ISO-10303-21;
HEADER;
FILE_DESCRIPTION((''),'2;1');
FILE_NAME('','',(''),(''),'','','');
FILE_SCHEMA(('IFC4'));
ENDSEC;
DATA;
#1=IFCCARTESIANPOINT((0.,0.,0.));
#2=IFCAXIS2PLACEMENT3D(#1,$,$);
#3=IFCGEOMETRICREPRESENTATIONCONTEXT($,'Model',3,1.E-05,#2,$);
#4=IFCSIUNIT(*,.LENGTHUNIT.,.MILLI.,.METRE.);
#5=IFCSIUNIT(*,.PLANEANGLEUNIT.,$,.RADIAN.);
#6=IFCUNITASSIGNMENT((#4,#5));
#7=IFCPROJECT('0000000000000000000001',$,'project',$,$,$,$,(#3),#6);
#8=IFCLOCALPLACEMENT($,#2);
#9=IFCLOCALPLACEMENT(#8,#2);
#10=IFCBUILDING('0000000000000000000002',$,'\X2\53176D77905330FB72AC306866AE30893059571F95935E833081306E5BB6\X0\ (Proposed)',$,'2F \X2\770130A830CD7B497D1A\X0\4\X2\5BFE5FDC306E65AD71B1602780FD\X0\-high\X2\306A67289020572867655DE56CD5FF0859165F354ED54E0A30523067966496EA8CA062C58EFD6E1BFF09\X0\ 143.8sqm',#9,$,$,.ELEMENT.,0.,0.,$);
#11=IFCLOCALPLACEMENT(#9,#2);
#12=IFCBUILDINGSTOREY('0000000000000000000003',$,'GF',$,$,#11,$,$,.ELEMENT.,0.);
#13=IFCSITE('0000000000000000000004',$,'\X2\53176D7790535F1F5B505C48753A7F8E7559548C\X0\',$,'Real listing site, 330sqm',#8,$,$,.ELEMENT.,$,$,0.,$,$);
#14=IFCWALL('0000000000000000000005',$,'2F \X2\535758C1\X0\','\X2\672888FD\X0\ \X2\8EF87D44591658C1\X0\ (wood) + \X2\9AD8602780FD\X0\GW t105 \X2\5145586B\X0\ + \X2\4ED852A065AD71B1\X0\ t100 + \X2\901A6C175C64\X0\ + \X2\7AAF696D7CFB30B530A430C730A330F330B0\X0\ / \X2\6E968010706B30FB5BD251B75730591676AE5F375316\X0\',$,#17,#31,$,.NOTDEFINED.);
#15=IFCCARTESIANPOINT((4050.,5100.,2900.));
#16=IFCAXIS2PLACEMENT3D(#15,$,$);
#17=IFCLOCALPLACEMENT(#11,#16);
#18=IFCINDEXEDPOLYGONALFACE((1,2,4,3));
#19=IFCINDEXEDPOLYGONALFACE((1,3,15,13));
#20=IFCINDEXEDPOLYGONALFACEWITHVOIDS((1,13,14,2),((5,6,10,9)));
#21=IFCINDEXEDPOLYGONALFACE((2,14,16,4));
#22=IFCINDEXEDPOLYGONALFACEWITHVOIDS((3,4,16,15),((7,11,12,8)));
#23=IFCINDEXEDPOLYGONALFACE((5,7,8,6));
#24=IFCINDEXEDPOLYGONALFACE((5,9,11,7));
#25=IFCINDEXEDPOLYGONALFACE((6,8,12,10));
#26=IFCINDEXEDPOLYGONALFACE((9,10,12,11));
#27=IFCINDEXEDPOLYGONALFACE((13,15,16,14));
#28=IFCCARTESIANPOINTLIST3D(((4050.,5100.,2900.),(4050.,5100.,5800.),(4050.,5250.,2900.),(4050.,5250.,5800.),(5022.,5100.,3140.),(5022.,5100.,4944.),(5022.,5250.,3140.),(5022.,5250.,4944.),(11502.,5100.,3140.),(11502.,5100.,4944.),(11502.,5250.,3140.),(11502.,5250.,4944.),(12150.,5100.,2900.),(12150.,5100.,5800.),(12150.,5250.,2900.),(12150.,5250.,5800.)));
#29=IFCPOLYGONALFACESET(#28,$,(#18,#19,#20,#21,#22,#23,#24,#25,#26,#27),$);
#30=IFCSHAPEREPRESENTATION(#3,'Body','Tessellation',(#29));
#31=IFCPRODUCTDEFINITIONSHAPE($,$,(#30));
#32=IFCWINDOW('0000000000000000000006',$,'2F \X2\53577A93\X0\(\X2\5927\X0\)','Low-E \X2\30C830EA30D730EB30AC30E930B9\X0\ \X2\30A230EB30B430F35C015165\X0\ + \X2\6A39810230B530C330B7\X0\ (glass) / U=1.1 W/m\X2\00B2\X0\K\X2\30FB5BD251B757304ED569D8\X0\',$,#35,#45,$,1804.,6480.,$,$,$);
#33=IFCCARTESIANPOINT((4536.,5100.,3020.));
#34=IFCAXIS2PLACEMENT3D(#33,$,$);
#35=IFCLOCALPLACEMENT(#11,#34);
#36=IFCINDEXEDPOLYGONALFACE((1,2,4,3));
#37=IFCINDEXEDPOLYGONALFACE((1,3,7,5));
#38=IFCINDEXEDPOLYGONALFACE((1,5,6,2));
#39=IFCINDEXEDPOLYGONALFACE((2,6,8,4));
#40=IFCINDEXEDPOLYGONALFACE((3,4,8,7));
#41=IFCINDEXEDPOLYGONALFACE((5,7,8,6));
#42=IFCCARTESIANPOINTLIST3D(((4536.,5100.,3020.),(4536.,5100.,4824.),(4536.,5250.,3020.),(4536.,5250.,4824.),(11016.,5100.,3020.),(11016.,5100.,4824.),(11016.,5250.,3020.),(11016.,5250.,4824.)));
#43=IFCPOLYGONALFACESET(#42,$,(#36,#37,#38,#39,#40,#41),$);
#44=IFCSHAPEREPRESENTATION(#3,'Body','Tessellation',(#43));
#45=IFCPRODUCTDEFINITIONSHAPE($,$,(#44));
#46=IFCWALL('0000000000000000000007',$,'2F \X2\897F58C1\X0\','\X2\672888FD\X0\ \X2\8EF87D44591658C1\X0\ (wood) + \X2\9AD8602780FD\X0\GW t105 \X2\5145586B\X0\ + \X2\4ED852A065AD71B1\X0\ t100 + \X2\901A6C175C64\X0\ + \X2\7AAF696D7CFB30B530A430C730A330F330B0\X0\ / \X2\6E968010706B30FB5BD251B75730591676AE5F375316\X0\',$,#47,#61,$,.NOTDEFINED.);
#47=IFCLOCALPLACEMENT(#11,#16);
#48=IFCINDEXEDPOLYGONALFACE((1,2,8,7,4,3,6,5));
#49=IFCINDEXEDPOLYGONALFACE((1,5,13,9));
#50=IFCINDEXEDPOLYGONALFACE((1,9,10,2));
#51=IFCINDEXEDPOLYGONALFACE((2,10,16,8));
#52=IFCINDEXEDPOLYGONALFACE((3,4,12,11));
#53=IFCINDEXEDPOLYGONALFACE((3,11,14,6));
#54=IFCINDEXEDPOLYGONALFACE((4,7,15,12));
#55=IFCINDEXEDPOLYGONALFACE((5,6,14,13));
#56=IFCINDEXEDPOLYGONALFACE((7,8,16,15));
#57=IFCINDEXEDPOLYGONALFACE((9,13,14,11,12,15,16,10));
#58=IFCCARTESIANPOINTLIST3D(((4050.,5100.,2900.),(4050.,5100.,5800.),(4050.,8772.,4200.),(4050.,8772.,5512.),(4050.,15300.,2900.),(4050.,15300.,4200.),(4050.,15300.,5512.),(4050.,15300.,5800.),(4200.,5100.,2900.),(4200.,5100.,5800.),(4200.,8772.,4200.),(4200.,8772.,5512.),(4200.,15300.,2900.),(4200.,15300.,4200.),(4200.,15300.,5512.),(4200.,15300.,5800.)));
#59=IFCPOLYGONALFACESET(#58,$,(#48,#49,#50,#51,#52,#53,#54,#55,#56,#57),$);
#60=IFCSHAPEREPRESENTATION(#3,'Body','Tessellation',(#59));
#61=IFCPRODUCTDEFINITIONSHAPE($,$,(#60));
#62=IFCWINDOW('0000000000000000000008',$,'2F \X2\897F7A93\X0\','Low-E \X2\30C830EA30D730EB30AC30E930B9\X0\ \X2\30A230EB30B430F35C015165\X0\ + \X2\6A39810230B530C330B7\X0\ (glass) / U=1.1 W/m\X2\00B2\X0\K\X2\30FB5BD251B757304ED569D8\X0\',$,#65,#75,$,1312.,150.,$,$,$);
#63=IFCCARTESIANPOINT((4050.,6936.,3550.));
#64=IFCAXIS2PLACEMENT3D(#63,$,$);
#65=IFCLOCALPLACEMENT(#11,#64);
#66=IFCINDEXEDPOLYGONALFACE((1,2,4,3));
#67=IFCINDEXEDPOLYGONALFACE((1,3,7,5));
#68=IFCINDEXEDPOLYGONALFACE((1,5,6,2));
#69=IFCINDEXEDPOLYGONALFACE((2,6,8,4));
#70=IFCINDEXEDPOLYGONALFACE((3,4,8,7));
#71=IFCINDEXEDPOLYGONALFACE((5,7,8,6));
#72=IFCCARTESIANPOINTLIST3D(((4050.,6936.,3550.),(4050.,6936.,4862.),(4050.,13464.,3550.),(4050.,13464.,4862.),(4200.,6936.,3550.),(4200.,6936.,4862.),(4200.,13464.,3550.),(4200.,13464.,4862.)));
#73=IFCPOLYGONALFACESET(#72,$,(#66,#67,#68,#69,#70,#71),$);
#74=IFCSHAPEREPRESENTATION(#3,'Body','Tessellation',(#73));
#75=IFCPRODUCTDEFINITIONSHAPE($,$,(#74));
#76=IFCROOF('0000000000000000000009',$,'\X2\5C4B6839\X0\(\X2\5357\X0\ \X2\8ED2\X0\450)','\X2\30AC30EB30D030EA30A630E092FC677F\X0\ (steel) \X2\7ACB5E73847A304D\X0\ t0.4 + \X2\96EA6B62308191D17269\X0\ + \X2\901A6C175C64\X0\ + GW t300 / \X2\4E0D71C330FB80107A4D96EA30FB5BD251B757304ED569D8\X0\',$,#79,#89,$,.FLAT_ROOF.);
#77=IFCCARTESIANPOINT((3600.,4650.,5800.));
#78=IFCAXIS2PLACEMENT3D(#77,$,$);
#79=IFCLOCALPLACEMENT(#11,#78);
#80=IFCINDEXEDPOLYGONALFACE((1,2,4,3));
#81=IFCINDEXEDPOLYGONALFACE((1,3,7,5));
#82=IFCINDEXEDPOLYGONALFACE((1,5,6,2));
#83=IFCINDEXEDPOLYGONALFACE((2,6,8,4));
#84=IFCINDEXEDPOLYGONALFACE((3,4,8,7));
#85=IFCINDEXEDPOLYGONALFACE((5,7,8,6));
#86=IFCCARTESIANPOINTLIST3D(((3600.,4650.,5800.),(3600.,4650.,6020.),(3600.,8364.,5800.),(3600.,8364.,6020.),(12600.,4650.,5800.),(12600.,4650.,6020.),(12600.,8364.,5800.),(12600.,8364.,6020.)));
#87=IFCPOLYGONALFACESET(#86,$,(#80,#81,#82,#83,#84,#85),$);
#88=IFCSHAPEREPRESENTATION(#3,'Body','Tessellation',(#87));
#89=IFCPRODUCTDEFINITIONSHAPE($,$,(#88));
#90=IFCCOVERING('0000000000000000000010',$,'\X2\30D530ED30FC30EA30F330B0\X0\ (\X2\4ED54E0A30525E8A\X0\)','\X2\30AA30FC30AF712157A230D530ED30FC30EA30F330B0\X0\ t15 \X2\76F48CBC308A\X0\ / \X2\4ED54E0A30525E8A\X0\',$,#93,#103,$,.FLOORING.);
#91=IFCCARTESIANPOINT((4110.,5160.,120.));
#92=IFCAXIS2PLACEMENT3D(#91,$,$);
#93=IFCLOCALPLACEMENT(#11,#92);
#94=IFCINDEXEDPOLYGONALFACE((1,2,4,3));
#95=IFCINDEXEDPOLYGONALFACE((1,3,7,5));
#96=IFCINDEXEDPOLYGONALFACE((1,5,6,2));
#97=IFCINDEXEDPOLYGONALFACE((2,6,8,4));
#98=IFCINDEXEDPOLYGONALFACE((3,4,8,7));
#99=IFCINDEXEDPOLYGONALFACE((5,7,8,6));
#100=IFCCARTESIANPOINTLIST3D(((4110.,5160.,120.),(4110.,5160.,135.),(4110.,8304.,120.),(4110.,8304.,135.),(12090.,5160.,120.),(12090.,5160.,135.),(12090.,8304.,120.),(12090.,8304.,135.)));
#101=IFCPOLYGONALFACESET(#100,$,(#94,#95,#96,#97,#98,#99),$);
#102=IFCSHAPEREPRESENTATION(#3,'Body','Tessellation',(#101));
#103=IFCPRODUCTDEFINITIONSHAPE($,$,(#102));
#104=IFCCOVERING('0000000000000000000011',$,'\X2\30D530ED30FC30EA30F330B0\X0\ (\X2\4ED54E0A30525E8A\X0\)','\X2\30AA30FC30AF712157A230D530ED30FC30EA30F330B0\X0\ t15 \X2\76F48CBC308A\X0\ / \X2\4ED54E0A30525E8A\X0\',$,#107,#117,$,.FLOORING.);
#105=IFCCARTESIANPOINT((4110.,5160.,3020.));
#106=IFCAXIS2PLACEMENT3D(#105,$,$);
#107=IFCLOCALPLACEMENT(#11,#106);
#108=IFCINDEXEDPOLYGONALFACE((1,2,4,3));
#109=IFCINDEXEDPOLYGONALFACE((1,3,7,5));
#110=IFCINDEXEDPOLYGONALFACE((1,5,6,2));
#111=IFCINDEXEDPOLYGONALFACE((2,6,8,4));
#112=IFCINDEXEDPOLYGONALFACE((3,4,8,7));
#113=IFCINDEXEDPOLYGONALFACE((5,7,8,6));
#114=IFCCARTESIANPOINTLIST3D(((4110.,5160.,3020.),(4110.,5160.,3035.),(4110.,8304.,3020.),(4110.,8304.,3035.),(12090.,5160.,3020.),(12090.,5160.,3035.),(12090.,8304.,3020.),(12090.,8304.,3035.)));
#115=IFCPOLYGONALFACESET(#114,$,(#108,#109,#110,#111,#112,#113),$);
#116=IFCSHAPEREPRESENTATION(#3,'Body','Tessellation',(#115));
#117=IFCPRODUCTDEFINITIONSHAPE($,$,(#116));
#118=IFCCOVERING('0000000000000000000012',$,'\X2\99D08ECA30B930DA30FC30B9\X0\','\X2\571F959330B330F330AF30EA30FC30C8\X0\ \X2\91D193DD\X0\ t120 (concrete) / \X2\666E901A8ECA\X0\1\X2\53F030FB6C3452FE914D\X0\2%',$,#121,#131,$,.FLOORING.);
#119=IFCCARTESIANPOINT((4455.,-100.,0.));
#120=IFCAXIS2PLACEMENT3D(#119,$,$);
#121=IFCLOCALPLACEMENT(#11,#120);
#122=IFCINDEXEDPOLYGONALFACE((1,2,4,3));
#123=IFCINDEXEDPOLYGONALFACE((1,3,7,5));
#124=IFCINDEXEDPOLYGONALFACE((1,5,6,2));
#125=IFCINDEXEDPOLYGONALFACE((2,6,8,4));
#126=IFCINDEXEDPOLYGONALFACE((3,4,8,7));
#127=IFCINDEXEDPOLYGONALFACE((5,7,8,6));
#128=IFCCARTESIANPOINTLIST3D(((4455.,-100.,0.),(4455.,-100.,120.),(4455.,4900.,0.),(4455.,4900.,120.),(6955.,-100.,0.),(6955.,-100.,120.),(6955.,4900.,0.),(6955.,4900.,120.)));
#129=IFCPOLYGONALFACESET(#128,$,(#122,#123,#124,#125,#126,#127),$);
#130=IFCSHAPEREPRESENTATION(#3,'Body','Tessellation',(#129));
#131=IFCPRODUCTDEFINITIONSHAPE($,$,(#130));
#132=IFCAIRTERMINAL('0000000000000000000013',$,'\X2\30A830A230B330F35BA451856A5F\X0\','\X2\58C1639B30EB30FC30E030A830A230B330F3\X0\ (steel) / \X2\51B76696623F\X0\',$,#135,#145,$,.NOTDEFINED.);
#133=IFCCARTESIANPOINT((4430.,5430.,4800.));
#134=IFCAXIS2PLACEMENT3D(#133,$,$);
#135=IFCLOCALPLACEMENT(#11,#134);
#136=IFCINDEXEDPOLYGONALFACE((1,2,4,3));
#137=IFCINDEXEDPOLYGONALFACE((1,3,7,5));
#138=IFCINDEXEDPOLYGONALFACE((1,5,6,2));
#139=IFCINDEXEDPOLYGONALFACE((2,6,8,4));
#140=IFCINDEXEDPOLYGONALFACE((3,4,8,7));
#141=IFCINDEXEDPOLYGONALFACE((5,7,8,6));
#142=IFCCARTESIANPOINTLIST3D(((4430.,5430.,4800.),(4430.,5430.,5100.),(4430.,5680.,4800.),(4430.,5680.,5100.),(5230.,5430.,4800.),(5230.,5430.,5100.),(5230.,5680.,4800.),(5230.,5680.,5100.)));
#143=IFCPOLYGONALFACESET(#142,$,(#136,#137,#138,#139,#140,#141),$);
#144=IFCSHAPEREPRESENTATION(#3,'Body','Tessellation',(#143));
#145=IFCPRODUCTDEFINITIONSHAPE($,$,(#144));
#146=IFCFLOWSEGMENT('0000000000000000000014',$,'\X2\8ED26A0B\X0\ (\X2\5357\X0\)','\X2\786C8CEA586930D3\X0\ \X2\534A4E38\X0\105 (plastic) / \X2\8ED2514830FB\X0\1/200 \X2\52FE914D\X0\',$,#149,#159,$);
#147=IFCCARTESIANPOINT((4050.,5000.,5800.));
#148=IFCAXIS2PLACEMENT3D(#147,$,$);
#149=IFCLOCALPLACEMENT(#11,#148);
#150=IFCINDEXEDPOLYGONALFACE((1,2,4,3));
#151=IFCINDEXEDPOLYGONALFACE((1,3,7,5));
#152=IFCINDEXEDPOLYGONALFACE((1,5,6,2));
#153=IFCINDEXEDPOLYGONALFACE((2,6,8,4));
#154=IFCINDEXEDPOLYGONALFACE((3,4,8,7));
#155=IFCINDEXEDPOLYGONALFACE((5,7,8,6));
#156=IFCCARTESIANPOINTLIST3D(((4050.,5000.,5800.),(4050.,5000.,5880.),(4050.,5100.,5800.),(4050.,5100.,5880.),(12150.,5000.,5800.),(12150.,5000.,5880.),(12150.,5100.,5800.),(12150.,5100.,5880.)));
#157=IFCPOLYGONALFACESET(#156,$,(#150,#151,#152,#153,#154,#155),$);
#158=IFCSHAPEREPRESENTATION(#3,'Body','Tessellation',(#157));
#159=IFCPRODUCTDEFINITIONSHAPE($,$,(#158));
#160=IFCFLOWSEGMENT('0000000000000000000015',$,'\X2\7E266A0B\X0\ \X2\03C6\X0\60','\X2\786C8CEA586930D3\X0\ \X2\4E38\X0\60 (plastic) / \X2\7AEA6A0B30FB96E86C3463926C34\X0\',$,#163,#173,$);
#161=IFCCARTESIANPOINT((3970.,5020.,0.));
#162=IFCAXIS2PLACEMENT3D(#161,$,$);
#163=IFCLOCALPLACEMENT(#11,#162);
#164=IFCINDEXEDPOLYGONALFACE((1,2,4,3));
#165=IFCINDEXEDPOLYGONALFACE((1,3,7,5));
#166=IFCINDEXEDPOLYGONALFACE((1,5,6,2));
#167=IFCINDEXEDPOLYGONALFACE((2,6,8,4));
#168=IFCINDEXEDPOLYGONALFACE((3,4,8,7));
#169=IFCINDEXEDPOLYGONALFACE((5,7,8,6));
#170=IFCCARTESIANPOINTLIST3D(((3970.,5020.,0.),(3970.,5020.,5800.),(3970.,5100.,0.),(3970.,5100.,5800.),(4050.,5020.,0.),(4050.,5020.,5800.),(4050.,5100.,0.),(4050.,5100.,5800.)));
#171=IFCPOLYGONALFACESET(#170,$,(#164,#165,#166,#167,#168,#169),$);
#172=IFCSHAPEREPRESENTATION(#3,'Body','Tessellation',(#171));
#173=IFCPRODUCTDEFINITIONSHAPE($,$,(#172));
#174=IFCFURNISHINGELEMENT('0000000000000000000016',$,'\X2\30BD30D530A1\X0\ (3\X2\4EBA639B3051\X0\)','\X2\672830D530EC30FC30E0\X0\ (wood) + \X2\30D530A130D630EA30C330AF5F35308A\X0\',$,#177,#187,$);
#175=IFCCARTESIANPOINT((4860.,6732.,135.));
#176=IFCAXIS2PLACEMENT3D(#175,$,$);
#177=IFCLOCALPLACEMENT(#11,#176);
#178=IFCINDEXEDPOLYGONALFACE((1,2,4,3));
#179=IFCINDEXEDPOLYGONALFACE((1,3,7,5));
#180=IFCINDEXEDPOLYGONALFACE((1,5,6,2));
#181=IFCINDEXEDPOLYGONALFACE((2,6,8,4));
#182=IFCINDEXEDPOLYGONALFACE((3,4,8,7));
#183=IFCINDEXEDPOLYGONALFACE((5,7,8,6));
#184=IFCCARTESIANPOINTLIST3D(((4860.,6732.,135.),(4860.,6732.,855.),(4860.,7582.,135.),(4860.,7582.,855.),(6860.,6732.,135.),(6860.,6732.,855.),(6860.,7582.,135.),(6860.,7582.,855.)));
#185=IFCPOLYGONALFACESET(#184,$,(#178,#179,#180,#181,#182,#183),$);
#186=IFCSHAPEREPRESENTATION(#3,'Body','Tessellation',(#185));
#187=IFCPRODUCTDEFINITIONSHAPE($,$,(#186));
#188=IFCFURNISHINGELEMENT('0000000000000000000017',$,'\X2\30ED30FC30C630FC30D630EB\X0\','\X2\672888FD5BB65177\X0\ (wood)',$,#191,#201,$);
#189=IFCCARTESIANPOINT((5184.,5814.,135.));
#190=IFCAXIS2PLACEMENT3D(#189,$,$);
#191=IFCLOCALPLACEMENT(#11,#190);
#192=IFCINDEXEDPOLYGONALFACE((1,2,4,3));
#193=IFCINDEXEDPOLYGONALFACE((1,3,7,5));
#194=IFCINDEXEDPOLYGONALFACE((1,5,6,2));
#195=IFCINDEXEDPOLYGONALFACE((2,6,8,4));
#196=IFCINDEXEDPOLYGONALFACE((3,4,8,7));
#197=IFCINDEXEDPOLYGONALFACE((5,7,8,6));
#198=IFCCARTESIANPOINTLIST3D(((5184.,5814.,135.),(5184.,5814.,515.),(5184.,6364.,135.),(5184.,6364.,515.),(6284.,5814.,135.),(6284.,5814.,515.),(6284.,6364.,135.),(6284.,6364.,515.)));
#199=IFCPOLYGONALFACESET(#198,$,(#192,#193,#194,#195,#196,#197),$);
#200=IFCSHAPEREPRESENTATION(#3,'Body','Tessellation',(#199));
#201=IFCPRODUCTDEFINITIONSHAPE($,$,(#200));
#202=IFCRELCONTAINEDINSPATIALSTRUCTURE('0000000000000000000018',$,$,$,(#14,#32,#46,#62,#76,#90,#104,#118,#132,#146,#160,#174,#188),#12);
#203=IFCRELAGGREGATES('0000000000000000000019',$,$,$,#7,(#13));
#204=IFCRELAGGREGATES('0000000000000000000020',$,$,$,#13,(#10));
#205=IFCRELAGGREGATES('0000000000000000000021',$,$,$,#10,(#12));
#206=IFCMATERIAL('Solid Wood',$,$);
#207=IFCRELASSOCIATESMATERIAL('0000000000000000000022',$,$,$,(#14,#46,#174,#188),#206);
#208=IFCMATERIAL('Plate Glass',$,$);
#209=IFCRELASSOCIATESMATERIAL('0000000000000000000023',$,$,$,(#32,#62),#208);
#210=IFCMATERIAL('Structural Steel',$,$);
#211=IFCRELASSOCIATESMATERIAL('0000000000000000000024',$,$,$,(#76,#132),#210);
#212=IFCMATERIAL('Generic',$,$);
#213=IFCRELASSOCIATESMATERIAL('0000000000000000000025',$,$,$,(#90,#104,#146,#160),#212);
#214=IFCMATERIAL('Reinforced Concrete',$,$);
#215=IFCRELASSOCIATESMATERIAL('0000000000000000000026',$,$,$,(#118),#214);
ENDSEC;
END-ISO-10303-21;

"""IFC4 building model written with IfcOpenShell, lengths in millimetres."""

from ifc_helpers import new_model, si_unit, frame, frame_2d, origin, place, context, project, spatial, rectangle, extrude, material, element, fill, save


model = new_model("IFC4")

# Units and contexts
model_context = context("Model", 3, precision=1e-05, world=origin())
ifc_project = project(units=[si_unit("LENGTHUNIT", "METRE", prefix="MILLI"), si_unit("PLANEANGLEUNIT", "RADIAN")], contexts=[model_context])

# Site, building, storey
site_placement = place(None, origin())
site = spatial("IfcSite", under=ifc_project, at=site_placement, Name="北海道弟子屈町美留和", ObjectType="Real listing site, 330sqm", CompositionType="ELEMENT", RefElevation=0.0)
building_placement = place(site_placement, origin())
building = spatial("IfcBuilding", under=site, at=building_placement, Name="北海道・犬と暮らす土間広めの家 (Proposed)", ObjectType="2F 省エネ等級4対応の断熱性能-highな木造在来工法（外張仕上げで除雪負担軽減） 143.8sqm", CompositionType="ELEMENT", ElevationOfRefHeight=0.0, ElevationOfTerrain=0.0)
storey_placement = place(building_placement, origin())
storey = spatial("IfcBuildingStorey", under=building, at=storey_placement, Name="GF", CompositionType="ELEMENT", Elevation=0.0)

# Shared definitions
ifc_material_1 = material(Name="Solid Wood")

# Shared definitions
ifc_material_2 = material(Name="Reinforced Concrete")

# Shared definitions
ifc_material_3 = material(Name="Plate Glass")

# Walls, openings, windows
wall_1_placement = place(storey_placement, frame((4050.0, 5100.0, 2900.0)))
wall_1 = element("IfcWall", 1, at=wall_1_placement, inside=storey, material=ifc_material_1, Name="2F 南壁", Description="木製 軸組外壁 (wood) + 高性能GW t105 充填 + 付加断熱 t100 + 通気層 + 窯業系サイディング / 準耐火・寒冷地外皮強化", PredefinedType="NOTDEFINED", context=model_context, shape_type="SweptSolid", body=[
    extrude(rectangle(XDim=8100.0, YDim=150.0, at=frame_2d((4050.0, 75.0))), frame((4050.0, 5100.0, 2900.0)), (0.0, 0.0, 1.0), 2900.0),
])
opening_1_placement = place(storey_placement, frame((4536.0, 5100.0, 3020.0)))
opening_1 = element("IfcOpeningElement", 2, at=opening_1_placement, cuts=wall_1, PredefinedType="NOTDEFINED", context=model_context, shape_type="SweptSolid", body=[
    extrude(rectangle(XDim=6480.0, YDim=150.0, at=frame_2d((3240.0, 75.0))), frame((4536.0, 5100.0, 3020.0)), (0.0, 0.0, 1.0), 1804.0),
])
window_1_placement = place(storey_placement, frame((4536.0, 5100.0, 3020.0)))
window_1 = element("IfcWindow", 3, at=window_1_placement, inside=storey, material=ifc_material_3, Name="2F 南窓(大)", Description="Low-E トリプルガラス アルゴン封入 + 樹脂サッシ (glass) / U=1.1 W/m²K・寒冷地仕様", OverallHeight=1804.0, OverallWidth=6480.0, context=model_context, shape_type="SweptSolid", body=[
    extrude(rectangle(XDim=6480.0, YDim=150.0, at=frame_2d((3240.0, 75.0))), frame((4536.0, 5100.0, 3020.0)), (0.0, 0.0, 1.0), 1804.0),
])
fill(opening_1, window_1)
wall_2_placement = place(storey_placement, frame((4050.0, 5100.0, 2900.0)))
wall_2 = element("IfcWall", 4, at=wall_2_placement, inside=storey, material=ifc_material_1, Name="2F 西壁", Description="木製 軸組外壁 (wood) + 高性能GW t105 充填 + 付加断熱 t100 + 通気層 + 窯業系サイディング / 準耐火・寒冷地外皮強化", PredefinedType="NOTDEFINED", context=model_context, shape_type="SweptSolid", body=[
    extrude(rectangle(XDim=150.0, YDim=10200.0, at=frame_2d((75.0, 5100.0))), frame((4050.0, 5100.0, 2900.0)), (0.0, 0.0, 1.0), 2900.0),
])
opening_2_placement = place(storey_placement, frame((4050.0, 6936.0, 3550.0)))
opening_2 = element("IfcOpeningElement", 5, at=opening_2_placement, cuts=wall_2, PredefinedType="NOTDEFINED", context=model_context, shape_type="SweptSolid", body=[
    extrude(rectangle(XDim=150.0, YDim=6528.0, at=frame_2d((75.0, 3264.0))), frame((4050.0, 6936.0, 3550.0)), (0.0, 0.0, 1.0), 1312.0),
])
window_2_placement = place(storey_placement, frame((4050.0, 6936.0, 3550.0)))
window_2 = element("IfcWindow", 6, at=window_2_placement, inside=storey, material=ifc_material_3, Name="2F 西窓", Description="Low-E トリプルガラス アルゴン封入 + 樹脂サッシ (glass) / U=1.1 W/m²K・寒冷地仕様", OverallHeight=1312.0, OverallWidth=150.0, context=model_context, shape_type="SweptSolid", body=[
    extrude(rectangle(XDim=150.0, YDim=6528.0, at=frame_2d((75.0, 3264.0))), frame((4050.0, 6936.0, 3550.0)), (0.0, 0.0, 1.0), 1312.0),
])
fill(opening_2, window_2)

# Roof
ifc_material_4 = material(Name="Structural Steel")
for number, where, name in (
    (7, (3600.0, 4650.0, 5800.0), "屋根(南 軒450)"),
):
    element("IfcRoof", number, at=place(storey_placement, frame(where)), inside=storey, material=ifc_material_4, Name=name, Description="ガルバリウム鋼板 (steel) 立平葺き t0.4 + 雪止め金物 + 通気層 + GW t300 / 不燃・耐積雪・寒冷地仕様", PredefinedType="FLAT_ROOF", context=model_context, shape_type="SweptSolid", body=[
        extrude(rectangle(XDim=9000.0, YDim=3714.0, at=frame_2d((4500.0, 1857.0))), frame((3600.0, 4650.0, 5800.0)), (0.0, 0.0, 1.0), 220.0),
    ])

# Coverings
ifc_material_5 = material(Name="Generic")
covering_1_placement = place(storey_placement, frame((4110.0, 5160.0, 120.0)))
element("IfcCovering", 8, at=covering_1_placement, inside=storey, material=ifc_material_5, Name="フローリング (仕上げ床)", Description="オーク無垢フローリング t15 直貼り / 仕上げ床", PredefinedType="FLOORING", context=model_context, shape_type="SweptSolid", body=[
    extrude(rectangle(XDim=7980.0, YDim=3144.0, at=frame_2d((3990.0, 1572.0))), frame((4110.0, 5160.0, 120.0)), (0.0, 0.0, 1.0), 15.0),
])
covering_2_placement = place(storey_placement, frame((4110.0, 5160.0, 3020.0)))
element("IfcCovering", 9, at=covering_2_placement, inside=storey, material=ifc_material_5, Name="フローリング (仕上げ床)", Description="オーク無垢フローリング t15 直貼り / 仕上げ床", PredefinedType="FLOORING", context=model_context, shape_type="SweptSolid", body=[
    extrude(rectangle(XDim=7980.0, YDim=3144.0, at=frame_2d((3990.0, 1572.0))), frame((4110.0, 5160.0, 3020.0)), (0.0, 0.0, 1.0), 15.0),
])
covering_3_placement = place(storey_placement, frame((4455.0, -100.0, 0.0)))
element("IfcCovering", 10, at=covering_3_placement, inside=storey, material=ifc_material_2, Name="駐車スペース", Description="土間コンクリート 金鏝 t120 (concrete) / 普通車1台・水勾配2%", PredefinedType="FLOORING", context=model_context, shape_type="SweptSolid", body=[
    extrude(rectangle(XDim=2500.0, YDim=5000.0, at=frame_2d((1250.0, 2500.0))), frame((4455.0, -100.0, 0.0)), (0.0, 0.0, 1.0), 120.0),
])

# Air terminal
air_terminal_placement = place(storey_placement, frame((4430.0, 5430.0, 4800.0)))
element("IfcAirTerminal", 11, at=air_terminal_placement, inside=storey, material=ifc_material_4, Name="エアコン室内機", Description="壁掛ルームエアコン (steel) / 冷暖房", PredefinedType="NOTDEFINED", context=model_context, shape_type="SweptSolid", body=[
    extrude(rectangle(XDim=800.0, YDim=250.0, at=frame_2d((400.0, 125.0))), frame((4430.0, 5430.0, 4800.0)), (0.0, 0.0, 1.0), 300.0),
])

# Flow segments
flow_segment_1_placement = place(storey_placement, frame((4050.0, 5000.0, 5800.0)))
element("IfcFlowSegment", 12, at=flow_segment_1_placement, inside=storey, material=ifc_material_5, Name="軒樋 (南)", Description="硬質塩ビ 半丸105 (plastic) / 軒先・1/200 勾配", context=model_context, shape_type="SweptSolid", body=[
    extrude(rectangle(XDim=8100.0, YDim=100.0, at=frame_2d((4050.0, 50.0))), frame((4050.0, 5000.0, 5800.0)), (0.0, 0.0, 1.0), 80.0),
])
flow_segment_2_placement = place(storey_placement, frame((3970.0, 5020.0, 0.0)))
element("IfcFlowSegment", 13, at=flow_segment_2_placement, inside=storey, material=ifc_material_5, Name="縦樋 φ60", Description="硬質塩ビ 丸60 (plastic) / 竪樋・雨水排水", context=model_context, shape_type="SweptSolid", body=[
    extrude(rectangle(XDim=80.0, YDim=80.0, at=frame_2d((40.0, 40.0))), frame((3970.0, 5020.0, 0.0)), (0.0, 0.0, 1.0), 5800.0),
])

# Furnishing elements
furnishing_1_placement = place(storey_placement, frame((4860.0, 6732.0, 135.0)))
element("IfcFurnishingElement", 14, at=furnishing_1_placement, inside=storey, material=ifc_material_1, Name="ソファ (3人掛け)", Description="木フレーム (wood) + ファブリック張り", context=model_context, shape_type="SweptSolid", body=[
    extrude(rectangle(XDim=2000.0, YDim=850.0, at=frame_2d((1000.0, 425.0))), frame((4860.0, 6732.0, 135.0)), (0.0, 0.0, 1.0), 720.0),
])
furnishing_2_placement = place(storey_placement, frame((5184.0, 5814.0, 135.0)))
element("IfcFurnishingElement", 15, at=furnishing_2_placement, inside=storey, material=ifc_material_1, Name="ローテーブル", Description="木製家具 (wood)", context=model_context, shape_type="SweptSolid", body=[
    extrude(rectangle(XDim=1100.0, YDim=550.0, at=frame_2d((550.0, 275.0))), frame((5184.0, 5814.0, 135.0)), (0.0, 0.0, 1.0), 380.0),
])

save(model, "model.ifc")
